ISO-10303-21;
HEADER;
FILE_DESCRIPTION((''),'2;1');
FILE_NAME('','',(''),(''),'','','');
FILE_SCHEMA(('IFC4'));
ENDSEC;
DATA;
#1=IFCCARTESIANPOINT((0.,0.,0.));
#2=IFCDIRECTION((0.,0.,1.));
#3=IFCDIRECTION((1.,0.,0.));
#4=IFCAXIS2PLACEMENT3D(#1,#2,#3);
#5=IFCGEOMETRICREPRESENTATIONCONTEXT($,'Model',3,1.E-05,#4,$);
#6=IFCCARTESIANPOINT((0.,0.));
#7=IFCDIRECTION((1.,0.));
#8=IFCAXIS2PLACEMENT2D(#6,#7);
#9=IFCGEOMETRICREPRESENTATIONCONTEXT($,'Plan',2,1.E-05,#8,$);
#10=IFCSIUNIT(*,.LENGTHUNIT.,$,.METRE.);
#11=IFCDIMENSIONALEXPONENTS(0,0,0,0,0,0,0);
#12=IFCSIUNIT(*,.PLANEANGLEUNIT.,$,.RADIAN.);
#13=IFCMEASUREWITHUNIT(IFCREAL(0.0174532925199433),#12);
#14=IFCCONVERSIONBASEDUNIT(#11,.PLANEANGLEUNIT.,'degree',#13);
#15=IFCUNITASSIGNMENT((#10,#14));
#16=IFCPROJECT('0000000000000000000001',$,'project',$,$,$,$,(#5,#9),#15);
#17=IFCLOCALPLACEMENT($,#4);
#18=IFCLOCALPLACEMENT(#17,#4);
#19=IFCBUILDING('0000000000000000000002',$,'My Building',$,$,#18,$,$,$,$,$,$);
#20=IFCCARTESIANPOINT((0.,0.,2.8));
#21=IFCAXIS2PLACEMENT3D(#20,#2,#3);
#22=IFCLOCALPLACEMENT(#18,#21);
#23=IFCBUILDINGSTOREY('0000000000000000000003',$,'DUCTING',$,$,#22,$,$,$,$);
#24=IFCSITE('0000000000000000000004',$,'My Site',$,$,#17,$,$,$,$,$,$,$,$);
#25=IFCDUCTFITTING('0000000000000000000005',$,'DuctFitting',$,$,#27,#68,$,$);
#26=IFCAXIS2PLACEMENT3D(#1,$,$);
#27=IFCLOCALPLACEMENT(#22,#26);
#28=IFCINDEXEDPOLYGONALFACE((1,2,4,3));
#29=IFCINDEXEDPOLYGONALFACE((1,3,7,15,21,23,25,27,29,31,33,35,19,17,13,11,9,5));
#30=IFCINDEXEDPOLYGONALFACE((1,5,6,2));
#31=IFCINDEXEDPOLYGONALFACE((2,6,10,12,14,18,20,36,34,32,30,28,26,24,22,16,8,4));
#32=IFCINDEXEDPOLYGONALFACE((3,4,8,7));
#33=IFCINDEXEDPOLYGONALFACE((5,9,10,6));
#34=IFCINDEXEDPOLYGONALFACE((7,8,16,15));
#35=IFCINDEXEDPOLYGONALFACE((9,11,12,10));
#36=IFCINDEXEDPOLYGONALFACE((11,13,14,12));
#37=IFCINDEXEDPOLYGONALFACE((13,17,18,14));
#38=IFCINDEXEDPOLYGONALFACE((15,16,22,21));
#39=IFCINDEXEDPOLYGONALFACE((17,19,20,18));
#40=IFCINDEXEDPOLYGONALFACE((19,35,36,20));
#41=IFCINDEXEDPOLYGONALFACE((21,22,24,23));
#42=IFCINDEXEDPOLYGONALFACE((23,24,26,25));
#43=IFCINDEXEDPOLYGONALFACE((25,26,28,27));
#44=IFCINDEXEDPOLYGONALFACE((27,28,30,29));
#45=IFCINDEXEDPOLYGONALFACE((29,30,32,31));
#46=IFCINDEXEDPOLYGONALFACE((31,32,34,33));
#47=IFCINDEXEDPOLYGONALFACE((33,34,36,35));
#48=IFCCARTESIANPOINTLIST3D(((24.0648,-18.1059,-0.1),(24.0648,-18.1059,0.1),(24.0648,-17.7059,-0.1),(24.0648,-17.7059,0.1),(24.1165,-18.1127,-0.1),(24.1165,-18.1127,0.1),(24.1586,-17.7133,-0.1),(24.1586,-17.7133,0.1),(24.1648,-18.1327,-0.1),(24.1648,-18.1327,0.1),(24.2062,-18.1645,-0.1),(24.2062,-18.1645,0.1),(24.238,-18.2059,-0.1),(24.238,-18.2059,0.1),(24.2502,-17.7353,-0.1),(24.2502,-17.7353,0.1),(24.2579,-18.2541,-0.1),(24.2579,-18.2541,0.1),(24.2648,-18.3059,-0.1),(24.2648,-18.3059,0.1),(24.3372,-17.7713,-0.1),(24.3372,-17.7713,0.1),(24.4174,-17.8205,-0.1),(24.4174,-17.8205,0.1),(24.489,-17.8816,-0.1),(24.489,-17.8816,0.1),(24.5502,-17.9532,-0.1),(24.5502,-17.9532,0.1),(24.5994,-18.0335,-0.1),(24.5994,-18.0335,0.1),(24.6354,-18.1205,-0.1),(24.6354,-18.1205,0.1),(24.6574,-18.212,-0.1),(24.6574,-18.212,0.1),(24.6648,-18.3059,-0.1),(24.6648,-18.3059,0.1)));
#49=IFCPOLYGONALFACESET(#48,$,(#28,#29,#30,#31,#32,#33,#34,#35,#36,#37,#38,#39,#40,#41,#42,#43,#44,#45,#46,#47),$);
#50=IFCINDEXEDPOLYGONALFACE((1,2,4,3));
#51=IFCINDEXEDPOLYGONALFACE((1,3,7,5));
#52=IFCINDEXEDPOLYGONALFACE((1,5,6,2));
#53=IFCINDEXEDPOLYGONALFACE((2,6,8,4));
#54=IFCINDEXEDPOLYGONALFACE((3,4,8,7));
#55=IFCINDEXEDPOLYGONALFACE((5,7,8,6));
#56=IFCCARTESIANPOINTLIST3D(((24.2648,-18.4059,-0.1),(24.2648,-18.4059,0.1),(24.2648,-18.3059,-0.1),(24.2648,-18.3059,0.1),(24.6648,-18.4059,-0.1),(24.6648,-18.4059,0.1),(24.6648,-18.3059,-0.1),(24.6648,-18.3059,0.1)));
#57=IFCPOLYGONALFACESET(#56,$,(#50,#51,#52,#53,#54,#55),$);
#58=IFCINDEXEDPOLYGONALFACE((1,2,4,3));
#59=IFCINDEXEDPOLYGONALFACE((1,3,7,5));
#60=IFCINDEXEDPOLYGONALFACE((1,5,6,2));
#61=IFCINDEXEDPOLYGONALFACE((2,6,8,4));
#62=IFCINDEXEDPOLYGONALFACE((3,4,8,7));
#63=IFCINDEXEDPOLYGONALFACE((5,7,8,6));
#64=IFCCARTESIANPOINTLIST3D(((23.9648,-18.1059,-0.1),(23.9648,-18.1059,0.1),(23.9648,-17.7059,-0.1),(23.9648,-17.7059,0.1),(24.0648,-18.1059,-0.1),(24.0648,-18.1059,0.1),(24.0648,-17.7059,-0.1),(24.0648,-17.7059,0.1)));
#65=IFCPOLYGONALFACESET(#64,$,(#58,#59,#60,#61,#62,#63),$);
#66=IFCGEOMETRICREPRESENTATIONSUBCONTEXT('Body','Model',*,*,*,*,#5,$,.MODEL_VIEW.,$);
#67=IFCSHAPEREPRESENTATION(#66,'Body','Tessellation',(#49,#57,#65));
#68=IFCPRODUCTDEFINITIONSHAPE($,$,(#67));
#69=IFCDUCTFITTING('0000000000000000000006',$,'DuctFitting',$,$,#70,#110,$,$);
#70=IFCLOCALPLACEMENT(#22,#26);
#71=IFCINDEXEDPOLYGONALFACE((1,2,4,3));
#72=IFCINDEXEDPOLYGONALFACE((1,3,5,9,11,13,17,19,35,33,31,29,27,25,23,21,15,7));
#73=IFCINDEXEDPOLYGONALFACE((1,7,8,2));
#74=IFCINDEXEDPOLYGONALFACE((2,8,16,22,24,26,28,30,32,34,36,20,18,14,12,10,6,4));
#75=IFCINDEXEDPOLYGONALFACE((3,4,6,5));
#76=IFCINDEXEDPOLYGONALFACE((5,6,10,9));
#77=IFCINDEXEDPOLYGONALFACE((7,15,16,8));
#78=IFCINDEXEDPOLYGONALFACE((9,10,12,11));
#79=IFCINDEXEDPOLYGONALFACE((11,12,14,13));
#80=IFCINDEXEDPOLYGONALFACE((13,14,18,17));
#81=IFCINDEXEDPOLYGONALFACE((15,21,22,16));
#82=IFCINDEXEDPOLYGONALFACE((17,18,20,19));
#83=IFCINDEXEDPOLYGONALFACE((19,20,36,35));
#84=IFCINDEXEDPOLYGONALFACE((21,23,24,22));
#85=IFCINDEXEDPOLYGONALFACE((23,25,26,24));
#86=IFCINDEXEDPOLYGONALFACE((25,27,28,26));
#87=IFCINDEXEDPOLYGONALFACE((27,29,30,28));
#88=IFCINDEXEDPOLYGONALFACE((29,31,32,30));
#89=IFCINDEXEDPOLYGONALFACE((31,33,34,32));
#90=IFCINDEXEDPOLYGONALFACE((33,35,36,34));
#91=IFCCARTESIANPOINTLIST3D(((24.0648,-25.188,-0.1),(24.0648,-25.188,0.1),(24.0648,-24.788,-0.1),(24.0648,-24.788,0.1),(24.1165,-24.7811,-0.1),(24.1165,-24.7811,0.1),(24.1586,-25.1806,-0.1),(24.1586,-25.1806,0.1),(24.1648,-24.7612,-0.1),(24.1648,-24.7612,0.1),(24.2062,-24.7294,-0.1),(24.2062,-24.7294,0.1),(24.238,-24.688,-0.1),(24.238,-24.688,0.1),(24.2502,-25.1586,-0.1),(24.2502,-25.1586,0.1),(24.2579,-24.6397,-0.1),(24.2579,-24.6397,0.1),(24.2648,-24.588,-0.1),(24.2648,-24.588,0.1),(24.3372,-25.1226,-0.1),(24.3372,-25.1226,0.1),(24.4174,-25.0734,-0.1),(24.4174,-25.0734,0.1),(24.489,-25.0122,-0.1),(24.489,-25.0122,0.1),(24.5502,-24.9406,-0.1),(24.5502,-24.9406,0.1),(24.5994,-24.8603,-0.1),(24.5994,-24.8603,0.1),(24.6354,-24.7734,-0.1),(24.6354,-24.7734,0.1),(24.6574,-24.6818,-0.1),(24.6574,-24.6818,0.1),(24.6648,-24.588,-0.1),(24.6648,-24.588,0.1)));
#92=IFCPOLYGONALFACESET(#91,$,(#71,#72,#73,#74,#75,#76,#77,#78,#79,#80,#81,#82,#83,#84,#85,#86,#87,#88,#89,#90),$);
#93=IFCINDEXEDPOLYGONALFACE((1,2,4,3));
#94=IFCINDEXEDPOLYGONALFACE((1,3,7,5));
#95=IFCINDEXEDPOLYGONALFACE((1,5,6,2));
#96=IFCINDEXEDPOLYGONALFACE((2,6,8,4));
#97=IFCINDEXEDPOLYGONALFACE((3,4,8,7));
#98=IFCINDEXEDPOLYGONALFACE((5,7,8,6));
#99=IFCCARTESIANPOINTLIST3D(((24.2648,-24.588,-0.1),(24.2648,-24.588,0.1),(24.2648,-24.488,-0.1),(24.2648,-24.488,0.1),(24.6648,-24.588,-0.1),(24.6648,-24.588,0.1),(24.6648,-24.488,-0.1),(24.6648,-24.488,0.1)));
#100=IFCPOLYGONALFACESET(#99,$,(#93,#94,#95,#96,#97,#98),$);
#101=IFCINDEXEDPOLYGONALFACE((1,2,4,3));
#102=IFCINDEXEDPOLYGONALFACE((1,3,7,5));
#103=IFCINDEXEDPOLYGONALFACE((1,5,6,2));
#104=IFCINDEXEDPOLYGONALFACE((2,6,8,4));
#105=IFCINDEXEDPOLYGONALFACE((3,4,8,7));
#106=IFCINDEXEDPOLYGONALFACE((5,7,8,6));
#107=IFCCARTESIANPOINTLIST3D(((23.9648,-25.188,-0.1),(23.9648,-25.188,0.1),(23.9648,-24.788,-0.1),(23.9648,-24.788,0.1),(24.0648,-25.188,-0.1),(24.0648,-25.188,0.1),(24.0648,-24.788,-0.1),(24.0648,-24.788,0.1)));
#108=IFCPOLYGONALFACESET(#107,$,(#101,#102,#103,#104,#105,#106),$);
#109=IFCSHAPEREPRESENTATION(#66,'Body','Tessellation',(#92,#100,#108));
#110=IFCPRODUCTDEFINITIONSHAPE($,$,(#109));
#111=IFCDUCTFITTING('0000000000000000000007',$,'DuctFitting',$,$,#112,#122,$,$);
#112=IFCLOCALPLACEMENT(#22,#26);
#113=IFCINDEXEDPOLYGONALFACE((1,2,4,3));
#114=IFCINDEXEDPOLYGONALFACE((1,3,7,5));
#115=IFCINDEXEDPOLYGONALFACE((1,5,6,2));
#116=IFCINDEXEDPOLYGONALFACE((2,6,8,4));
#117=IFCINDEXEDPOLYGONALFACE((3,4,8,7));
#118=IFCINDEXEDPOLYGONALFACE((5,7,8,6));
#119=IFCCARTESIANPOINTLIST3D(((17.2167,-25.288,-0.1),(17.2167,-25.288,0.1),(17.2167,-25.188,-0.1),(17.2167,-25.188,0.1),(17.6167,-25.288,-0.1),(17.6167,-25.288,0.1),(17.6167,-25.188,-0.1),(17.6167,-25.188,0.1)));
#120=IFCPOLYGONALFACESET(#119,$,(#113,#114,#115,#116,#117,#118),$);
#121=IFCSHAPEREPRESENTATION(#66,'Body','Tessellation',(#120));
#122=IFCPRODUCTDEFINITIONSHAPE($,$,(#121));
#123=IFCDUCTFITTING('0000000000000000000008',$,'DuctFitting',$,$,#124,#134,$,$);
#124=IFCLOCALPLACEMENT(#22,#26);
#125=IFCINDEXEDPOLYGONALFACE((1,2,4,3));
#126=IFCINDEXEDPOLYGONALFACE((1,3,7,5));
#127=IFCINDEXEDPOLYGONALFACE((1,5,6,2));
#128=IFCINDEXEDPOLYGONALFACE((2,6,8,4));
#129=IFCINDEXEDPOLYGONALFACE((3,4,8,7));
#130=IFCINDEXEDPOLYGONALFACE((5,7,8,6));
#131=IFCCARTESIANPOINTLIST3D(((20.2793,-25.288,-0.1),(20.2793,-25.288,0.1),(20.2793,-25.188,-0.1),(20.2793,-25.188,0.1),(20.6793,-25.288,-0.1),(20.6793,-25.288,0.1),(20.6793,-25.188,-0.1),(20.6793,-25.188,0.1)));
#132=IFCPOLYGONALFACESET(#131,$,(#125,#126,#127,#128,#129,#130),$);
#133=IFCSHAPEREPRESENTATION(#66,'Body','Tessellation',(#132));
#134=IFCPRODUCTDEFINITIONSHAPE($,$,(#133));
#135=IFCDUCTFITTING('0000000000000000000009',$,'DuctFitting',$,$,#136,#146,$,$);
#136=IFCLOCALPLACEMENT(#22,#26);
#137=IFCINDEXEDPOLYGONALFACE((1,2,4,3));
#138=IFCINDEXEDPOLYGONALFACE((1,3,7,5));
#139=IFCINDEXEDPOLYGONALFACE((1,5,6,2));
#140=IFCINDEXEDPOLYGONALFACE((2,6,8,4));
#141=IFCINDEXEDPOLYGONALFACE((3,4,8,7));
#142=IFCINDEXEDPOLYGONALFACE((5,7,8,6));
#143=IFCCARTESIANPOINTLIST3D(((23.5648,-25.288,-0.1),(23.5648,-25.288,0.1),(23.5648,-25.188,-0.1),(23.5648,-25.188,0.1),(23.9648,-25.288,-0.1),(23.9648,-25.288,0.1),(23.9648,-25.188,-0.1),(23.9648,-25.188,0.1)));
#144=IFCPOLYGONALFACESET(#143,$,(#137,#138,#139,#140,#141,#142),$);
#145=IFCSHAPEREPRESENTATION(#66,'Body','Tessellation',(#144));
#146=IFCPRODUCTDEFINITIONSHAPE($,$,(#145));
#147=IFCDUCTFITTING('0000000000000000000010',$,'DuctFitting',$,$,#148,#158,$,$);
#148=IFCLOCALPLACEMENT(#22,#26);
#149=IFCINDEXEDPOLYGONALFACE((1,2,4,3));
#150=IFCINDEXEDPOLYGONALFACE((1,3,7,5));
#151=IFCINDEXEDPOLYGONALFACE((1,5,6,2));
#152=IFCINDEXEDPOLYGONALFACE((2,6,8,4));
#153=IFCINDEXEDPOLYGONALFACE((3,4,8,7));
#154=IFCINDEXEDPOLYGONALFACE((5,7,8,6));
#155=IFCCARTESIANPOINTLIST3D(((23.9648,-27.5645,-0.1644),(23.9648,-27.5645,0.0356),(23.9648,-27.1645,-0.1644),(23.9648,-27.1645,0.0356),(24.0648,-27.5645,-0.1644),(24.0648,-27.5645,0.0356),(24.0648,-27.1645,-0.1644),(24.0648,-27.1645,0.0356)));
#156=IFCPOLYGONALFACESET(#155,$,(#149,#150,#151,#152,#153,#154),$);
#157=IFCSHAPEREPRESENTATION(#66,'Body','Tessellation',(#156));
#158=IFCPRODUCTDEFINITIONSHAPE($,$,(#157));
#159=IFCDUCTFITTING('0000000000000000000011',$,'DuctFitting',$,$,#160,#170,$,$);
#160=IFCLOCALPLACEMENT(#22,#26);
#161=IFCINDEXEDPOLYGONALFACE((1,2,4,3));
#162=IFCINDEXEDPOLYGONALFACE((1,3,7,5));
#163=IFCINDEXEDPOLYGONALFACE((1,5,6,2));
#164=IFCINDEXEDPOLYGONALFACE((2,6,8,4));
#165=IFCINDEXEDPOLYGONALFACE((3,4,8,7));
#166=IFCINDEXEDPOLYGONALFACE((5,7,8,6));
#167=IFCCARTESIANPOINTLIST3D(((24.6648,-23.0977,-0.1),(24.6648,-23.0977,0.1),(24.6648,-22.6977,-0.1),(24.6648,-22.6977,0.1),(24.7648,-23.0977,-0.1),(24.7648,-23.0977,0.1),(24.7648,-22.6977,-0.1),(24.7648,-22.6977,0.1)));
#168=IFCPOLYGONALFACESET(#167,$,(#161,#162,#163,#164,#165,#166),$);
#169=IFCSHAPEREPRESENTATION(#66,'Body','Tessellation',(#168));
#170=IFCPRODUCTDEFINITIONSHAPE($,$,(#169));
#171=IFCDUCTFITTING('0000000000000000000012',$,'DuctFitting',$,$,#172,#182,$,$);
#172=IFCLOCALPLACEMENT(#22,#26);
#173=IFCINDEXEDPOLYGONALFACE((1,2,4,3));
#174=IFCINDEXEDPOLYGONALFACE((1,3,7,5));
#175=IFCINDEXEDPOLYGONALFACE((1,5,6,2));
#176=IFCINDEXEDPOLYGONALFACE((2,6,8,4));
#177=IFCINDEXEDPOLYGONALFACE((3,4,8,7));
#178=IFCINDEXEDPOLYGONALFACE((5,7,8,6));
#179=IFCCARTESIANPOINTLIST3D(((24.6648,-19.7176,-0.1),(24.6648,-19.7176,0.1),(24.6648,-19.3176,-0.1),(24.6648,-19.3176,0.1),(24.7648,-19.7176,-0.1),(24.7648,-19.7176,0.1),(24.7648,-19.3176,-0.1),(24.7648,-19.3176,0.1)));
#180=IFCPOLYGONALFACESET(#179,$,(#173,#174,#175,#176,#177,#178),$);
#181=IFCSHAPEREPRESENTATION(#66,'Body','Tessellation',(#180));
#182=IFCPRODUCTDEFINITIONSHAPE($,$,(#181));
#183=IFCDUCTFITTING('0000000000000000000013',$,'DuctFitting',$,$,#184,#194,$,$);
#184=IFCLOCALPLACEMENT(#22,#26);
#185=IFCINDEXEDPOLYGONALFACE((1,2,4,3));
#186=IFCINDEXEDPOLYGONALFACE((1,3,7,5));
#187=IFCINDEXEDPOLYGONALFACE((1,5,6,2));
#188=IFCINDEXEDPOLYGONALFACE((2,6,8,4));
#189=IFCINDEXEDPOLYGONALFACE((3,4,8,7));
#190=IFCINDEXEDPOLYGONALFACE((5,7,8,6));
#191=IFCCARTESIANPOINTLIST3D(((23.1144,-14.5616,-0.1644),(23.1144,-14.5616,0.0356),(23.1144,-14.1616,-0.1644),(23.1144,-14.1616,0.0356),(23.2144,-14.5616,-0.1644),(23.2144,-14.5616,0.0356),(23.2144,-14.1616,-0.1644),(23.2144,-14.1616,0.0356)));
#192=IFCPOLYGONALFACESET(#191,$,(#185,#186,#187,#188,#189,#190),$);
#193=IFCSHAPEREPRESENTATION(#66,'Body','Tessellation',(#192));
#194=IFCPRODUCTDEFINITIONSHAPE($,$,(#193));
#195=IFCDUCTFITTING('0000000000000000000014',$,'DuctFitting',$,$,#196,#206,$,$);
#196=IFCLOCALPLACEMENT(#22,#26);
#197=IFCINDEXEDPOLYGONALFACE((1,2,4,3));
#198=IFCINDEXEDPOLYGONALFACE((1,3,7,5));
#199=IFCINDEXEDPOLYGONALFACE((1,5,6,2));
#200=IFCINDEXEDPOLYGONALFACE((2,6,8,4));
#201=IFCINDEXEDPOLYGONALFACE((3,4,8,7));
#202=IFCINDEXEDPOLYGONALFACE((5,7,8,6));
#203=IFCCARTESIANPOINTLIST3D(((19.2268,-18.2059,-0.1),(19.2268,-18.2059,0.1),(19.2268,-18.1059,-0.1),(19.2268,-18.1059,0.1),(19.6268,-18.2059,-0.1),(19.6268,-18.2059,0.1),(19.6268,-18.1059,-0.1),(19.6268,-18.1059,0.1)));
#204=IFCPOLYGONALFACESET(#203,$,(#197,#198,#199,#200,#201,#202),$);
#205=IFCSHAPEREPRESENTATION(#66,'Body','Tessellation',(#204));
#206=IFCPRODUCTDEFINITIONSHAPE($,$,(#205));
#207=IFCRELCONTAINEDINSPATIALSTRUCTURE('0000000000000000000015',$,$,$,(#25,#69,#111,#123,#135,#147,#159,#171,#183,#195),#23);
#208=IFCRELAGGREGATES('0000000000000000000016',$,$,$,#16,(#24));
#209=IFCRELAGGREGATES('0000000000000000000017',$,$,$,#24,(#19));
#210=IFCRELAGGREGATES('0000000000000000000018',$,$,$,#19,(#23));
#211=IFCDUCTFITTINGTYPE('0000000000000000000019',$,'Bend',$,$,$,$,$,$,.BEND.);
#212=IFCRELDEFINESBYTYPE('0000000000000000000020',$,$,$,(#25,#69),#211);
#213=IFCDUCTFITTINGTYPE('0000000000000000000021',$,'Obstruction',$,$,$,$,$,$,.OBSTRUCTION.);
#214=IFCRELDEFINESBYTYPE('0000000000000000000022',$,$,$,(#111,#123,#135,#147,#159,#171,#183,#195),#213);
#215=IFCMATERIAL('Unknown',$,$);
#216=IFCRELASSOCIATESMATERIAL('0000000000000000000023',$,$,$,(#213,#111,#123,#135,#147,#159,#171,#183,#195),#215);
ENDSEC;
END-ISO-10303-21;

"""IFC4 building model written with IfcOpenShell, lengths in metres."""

from ifc_helpers import new_model, entity, si_unit, converted_unit, frame, origin_with_axes, origin_2d_with_axis, place, context, subcontext, project, spatial, line, arc, indexed_curve, rectangle, outline, extrude, source, transform, mapped, material, material_profile, profile_set, profile_usage, type_object, type_shapes, element, save


model = new_model("IFC4")

# Units and contexts
model_context = context("Model", 3, precision=1e-05, world=origin_with_axes())
plan_context = context("Plan", 2, precision=1e-05, world=origin_2d_with_axis())
body_context = subcontext(model_context, "Body", "Model", "MODEL_VIEW")
ifc_project = project(units=[si_unit("LENGTHUNIT", "METRE"), converted_unit("PLANEANGLEUNIT", "degree", entity("IfcReal", 0.0174532925199433), si_unit("PLANEANGLEUNIT", "RADIAN"), dimensions=[0, 0, 0, 0, 0, 0, 0])], contexts=[model_context, plan_context])

# Site, building, storey
site_placement = place(None, origin_with_axes())
site = spatial("IfcSite", under=ifc_project, at=site_placement, Name="My Site")
building_placement = place(site_placement, origin_with_axes())
building = spatial("IfcBuilding", under=site, at=building_placement, Name="My Building")
storey_placement = place(building_placement, frame((0.0, 0.0, 2.8), z_axis=(0.0, 0.0, 1.0), x_axis=(1.0, 0.0, 0.0)))
storey = spatial("IfcBuildingStorey", under=building, at=storey_placement, Name="DUCTING")

# Shared definitions
ifc_material = material(Name="Unknown")

# Duct fittings
duct_fitting_type_1 = type_object("IfcDuctFittingType", Name="Bend", PredefinedType="BEND")
shared_shape = source(origin_with_axes(), body_context, "Body", "SweptSolid", [
    extrude(outline(indexed_curve([(-0.2, 0.0), (-0.2586, -0.1414), (-0.4, -0.2), (-0.4, -0.6), (0.0243, -0.4243), (0.2, 0.0)], segments=[arc(1, 2, 3), line(3, 4), arc(4, 5, 6), line(6, 1)])), frame((0.0, -0.1, -0.1), z_axis=(0.0, -1.0, 0.0), x_axis=(1.0, 0.0, 0.0)), (0.0, 0.0, -1.0), 0.2),
    extrude(rectangle(XDim=0.4, YDim=0.2), origin_with_axes(), (0.0, 0.0, -1.0), 0.1),
    extrude(rectangle(XDim=0.4, YDim=0.2), frame((-0.4, 0.0, -0.5), z_axis=(-1.0, 0.0, 0.0), x_axis=(0.0, 0.0, -1.0)), (0.0, 0.0, 1.0), 0.1),
])
type_shapes(duct_fitting_type_1, [shared_shape])
for number, where, z_axis, x_axis, name in (
    (1, (24.4648, -18.4059, 0.0), (0.0, -1.0, 0.0), (1.0, 0.0, 0.0), "DuctFitting"),
    (2, (24.4648, -24.488, 0.0), (0.0, 1.0, 0.0), (1.0, 0.0, 0.0), "DuctFitting"),
):
    element("IfcDuctFitting", number, at=place(storey_placement, frame(where, z_axis=z_axis, x_axis=x_axis)), inside=storey, type_object=duct_fitting_type_1, Name=name, context=body_context, shape_type="MappedRepresentation", body=[
        mapped(shared_shape, transform((0.0, 0.0, 0.0), x_axis=(1.0, 0.0, 0.0), y_axis=(0.0, 1.0, 0.0), z_axis=(0.0, 0.0, 1.0), scale=1.0)),
    ])
ifc_material_profile_1 = material_profile(ifc_material, rectangle(XDim=0.4, YDim=0.2))
ifc_profile_set_1 = profile_set([ifc_material_profile_1])
ifc_profile_usage_1 = profile_usage(ifc_profile_set_1, cardinal=5)
duct_fitting_type_2 = type_object("IfcDuctFittingType", Name="Obstruction", PredefinedType="OBSTRUCTION", material=ifc_profile_set_1)
duct_fitting_1_placement = place(storey_placement, frame((17.4167, -25.288, 0.0), z_axis=(0.0, 1.0, 0.0), x_axis=(1.0, 0.0, 0.0)))
element("IfcDuctFitting", 3, at=duct_fitting_1_placement, inside=storey, type_object=duct_fitting_type_2, material=ifc_profile_usage_1, Name="DuctFitting", context=body_context, shape_type="SweptSolid", body=[
    extrude(rectangle(XDim=0.4, YDim=0.2), origin_with_axes(), (0.0, 0.0, 1.0), 0.1),
])
ifc_profile_usage_2 = profile_usage(ifc_profile_set_1, cardinal=5)
duct_fitting_2_placement = place(storey_placement, frame((20.4793, -25.288, 0.0), z_axis=(0.0, 1.0, 0.0), x_axis=(1.0, 0.0, 0.0)))
element("IfcDuctFitting", 4, at=duct_fitting_2_placement, inside=storey, type_object=duct_fitting_type_2, material=ifc_profile_usage_2, Name="DuctFitting", context=body_context, shape_type="SweptSolid", body=[
    extrude(rectangle(XDim=0.4, YDim=0.2), origin_with_axes(), (0.0, 0.0, 1.0), 0.1),
])
ifc_profile_usage_3 = profile_usage(ifc_profile_set_1, cardinal=5)
duct_fitting_3_placement = place(storey_placement, frame((23.7648, -25.288, 0.0), z_axis=(0.0, 1.0, 0.0), x_axis=(1.0, 0.0, 0.0)))
element("IfcDuctFitting", 5, at=duct_fitting_3_placement, inside=storey, type_object=duct_fitting_type_2, material=ifc_profile_usage_3, Name="DuctFitting", context=body_context, shape_type="SweptSolid", body=[
    extrude(rectangle(XDim=0.4, YDim=0.2), origin_with_axes(), (0.0, 0.0, 1.0), 0.1),
])
ifc_profile_usage_4 = profile_usage(ifc_profile_set_1, cardinal=5)
duct_fitting_4_placement = place(storey_placement, frame((24.0648, -27.3645, -0.0644), z_axis=(-1.0, 0.0, 0.0), x_axis=(0.0, 1.0, 0.0)))
element("IfcDuctFitting", 6, at=duct_fitting_4_placement, inside=storey, type_object=duct_fitting_type_2, material=ifc_profile_usage_4, Name="DuctFitting", context=body_context, shape_type="SweptSolid", body=[
    extrude(rectangle(XDim=0.4, YDim=0.2), origin_with_axes(), (0.0, 0.0, 1.0), 0.1),
])
ifc_profile_usage_5 = profile_usage(ifc_profile_set_1, cardinal=5)
duct_fitting_5_placement = place(storey_placement, frame((24.7648, -22.8977, 0.0), z_axis=(-1.0, 0.0, 0.0), x_axis=(0.0, 1.0, 0.0)))
element("IfcDuctFitting", 7, at=duct_fitting_5_placement, inside=storey, type_object=duct_fitting_type_2, material=ifc_profile_usage_5, Name="DuctFitting", context=body_context, shape_type="SweptSolid", body=[
    extrude(rectangle(XDim=0.4, YDim=0.2), origin_with_axes(), (0.0, 0.0, 1.0), 0.1),
])
ifc_profile_usage_6 = profile_usage(ifc_profile_set_1, cardinal=5)
duct_fitting_6_placement = place(storey_placement, frame((24.7648, -19.5176, 0.0), z_axis=(-1.0, 0.0, 0.0), x_axis=(0.0, 1.0, 0.0)))
element("IfcDuctFitting", 8, at=duct_fitting_6_placement, inside=storey, type_object=duct_fitting_type_2, material=ifc_profile_usage_6, Name="DuctFitting", context=body_context, shape_type="SweptSolid", body=[
    extrude(rectangle(XDim=0.4, YDim=0.2), origin_with_axes(), (0.0, 0.0, 1.0), 0.1),
])
ifc_profile_usage_7 = profile_usage(ifc_profile_set_1, cardinal=5)
duct_fitting_7_placement = place(storey_placement, frame((23.2144, -14.3616, -0.0644), z_axis=(-1.0, 0.0, 0.0), x_axis=(0.0, 1.0, 0.0)))
element("IfcDuctFitting", 9, at=duct_fitting_7_placement, inside=storey, type_object=duct_fitting_type_2, material=ifc_profile_usage_7, Name="DuctFitting", context=body_context, shape_type="SweptSolid", body=[
    extrude(rectangle(XDim=0.4, YDim=0.2), origin_with_axes(), (0.0, 0.0, 1.0), 0.1),
])
ifc_profile_usage_8 = profile_usage(ifc_profile_set_1, cardinal=5)
duct_fitting_8_placement = place(storey_placement, frame((19.4268, -18.2059, 0.0), z_axis=(0.0, 1.0, 0.0), x_axis=(1.0, 0.0, 0.0)))
element("IfcDuctFitting", 10, at=duct_fitting_8_placement, inside=storey, type_object=duct_fitting_type_2, material=ifc_profile_usage_8, Name="DuctFitting", context=body_context, shape_type="SweptSolid", body=[
    extrude(rectangle(XDim=0.4, YDim=0.2), origin_with_axes(), (0.0, 0.0, 1.0), 0.1),
])

save(model, "model.ifc")
